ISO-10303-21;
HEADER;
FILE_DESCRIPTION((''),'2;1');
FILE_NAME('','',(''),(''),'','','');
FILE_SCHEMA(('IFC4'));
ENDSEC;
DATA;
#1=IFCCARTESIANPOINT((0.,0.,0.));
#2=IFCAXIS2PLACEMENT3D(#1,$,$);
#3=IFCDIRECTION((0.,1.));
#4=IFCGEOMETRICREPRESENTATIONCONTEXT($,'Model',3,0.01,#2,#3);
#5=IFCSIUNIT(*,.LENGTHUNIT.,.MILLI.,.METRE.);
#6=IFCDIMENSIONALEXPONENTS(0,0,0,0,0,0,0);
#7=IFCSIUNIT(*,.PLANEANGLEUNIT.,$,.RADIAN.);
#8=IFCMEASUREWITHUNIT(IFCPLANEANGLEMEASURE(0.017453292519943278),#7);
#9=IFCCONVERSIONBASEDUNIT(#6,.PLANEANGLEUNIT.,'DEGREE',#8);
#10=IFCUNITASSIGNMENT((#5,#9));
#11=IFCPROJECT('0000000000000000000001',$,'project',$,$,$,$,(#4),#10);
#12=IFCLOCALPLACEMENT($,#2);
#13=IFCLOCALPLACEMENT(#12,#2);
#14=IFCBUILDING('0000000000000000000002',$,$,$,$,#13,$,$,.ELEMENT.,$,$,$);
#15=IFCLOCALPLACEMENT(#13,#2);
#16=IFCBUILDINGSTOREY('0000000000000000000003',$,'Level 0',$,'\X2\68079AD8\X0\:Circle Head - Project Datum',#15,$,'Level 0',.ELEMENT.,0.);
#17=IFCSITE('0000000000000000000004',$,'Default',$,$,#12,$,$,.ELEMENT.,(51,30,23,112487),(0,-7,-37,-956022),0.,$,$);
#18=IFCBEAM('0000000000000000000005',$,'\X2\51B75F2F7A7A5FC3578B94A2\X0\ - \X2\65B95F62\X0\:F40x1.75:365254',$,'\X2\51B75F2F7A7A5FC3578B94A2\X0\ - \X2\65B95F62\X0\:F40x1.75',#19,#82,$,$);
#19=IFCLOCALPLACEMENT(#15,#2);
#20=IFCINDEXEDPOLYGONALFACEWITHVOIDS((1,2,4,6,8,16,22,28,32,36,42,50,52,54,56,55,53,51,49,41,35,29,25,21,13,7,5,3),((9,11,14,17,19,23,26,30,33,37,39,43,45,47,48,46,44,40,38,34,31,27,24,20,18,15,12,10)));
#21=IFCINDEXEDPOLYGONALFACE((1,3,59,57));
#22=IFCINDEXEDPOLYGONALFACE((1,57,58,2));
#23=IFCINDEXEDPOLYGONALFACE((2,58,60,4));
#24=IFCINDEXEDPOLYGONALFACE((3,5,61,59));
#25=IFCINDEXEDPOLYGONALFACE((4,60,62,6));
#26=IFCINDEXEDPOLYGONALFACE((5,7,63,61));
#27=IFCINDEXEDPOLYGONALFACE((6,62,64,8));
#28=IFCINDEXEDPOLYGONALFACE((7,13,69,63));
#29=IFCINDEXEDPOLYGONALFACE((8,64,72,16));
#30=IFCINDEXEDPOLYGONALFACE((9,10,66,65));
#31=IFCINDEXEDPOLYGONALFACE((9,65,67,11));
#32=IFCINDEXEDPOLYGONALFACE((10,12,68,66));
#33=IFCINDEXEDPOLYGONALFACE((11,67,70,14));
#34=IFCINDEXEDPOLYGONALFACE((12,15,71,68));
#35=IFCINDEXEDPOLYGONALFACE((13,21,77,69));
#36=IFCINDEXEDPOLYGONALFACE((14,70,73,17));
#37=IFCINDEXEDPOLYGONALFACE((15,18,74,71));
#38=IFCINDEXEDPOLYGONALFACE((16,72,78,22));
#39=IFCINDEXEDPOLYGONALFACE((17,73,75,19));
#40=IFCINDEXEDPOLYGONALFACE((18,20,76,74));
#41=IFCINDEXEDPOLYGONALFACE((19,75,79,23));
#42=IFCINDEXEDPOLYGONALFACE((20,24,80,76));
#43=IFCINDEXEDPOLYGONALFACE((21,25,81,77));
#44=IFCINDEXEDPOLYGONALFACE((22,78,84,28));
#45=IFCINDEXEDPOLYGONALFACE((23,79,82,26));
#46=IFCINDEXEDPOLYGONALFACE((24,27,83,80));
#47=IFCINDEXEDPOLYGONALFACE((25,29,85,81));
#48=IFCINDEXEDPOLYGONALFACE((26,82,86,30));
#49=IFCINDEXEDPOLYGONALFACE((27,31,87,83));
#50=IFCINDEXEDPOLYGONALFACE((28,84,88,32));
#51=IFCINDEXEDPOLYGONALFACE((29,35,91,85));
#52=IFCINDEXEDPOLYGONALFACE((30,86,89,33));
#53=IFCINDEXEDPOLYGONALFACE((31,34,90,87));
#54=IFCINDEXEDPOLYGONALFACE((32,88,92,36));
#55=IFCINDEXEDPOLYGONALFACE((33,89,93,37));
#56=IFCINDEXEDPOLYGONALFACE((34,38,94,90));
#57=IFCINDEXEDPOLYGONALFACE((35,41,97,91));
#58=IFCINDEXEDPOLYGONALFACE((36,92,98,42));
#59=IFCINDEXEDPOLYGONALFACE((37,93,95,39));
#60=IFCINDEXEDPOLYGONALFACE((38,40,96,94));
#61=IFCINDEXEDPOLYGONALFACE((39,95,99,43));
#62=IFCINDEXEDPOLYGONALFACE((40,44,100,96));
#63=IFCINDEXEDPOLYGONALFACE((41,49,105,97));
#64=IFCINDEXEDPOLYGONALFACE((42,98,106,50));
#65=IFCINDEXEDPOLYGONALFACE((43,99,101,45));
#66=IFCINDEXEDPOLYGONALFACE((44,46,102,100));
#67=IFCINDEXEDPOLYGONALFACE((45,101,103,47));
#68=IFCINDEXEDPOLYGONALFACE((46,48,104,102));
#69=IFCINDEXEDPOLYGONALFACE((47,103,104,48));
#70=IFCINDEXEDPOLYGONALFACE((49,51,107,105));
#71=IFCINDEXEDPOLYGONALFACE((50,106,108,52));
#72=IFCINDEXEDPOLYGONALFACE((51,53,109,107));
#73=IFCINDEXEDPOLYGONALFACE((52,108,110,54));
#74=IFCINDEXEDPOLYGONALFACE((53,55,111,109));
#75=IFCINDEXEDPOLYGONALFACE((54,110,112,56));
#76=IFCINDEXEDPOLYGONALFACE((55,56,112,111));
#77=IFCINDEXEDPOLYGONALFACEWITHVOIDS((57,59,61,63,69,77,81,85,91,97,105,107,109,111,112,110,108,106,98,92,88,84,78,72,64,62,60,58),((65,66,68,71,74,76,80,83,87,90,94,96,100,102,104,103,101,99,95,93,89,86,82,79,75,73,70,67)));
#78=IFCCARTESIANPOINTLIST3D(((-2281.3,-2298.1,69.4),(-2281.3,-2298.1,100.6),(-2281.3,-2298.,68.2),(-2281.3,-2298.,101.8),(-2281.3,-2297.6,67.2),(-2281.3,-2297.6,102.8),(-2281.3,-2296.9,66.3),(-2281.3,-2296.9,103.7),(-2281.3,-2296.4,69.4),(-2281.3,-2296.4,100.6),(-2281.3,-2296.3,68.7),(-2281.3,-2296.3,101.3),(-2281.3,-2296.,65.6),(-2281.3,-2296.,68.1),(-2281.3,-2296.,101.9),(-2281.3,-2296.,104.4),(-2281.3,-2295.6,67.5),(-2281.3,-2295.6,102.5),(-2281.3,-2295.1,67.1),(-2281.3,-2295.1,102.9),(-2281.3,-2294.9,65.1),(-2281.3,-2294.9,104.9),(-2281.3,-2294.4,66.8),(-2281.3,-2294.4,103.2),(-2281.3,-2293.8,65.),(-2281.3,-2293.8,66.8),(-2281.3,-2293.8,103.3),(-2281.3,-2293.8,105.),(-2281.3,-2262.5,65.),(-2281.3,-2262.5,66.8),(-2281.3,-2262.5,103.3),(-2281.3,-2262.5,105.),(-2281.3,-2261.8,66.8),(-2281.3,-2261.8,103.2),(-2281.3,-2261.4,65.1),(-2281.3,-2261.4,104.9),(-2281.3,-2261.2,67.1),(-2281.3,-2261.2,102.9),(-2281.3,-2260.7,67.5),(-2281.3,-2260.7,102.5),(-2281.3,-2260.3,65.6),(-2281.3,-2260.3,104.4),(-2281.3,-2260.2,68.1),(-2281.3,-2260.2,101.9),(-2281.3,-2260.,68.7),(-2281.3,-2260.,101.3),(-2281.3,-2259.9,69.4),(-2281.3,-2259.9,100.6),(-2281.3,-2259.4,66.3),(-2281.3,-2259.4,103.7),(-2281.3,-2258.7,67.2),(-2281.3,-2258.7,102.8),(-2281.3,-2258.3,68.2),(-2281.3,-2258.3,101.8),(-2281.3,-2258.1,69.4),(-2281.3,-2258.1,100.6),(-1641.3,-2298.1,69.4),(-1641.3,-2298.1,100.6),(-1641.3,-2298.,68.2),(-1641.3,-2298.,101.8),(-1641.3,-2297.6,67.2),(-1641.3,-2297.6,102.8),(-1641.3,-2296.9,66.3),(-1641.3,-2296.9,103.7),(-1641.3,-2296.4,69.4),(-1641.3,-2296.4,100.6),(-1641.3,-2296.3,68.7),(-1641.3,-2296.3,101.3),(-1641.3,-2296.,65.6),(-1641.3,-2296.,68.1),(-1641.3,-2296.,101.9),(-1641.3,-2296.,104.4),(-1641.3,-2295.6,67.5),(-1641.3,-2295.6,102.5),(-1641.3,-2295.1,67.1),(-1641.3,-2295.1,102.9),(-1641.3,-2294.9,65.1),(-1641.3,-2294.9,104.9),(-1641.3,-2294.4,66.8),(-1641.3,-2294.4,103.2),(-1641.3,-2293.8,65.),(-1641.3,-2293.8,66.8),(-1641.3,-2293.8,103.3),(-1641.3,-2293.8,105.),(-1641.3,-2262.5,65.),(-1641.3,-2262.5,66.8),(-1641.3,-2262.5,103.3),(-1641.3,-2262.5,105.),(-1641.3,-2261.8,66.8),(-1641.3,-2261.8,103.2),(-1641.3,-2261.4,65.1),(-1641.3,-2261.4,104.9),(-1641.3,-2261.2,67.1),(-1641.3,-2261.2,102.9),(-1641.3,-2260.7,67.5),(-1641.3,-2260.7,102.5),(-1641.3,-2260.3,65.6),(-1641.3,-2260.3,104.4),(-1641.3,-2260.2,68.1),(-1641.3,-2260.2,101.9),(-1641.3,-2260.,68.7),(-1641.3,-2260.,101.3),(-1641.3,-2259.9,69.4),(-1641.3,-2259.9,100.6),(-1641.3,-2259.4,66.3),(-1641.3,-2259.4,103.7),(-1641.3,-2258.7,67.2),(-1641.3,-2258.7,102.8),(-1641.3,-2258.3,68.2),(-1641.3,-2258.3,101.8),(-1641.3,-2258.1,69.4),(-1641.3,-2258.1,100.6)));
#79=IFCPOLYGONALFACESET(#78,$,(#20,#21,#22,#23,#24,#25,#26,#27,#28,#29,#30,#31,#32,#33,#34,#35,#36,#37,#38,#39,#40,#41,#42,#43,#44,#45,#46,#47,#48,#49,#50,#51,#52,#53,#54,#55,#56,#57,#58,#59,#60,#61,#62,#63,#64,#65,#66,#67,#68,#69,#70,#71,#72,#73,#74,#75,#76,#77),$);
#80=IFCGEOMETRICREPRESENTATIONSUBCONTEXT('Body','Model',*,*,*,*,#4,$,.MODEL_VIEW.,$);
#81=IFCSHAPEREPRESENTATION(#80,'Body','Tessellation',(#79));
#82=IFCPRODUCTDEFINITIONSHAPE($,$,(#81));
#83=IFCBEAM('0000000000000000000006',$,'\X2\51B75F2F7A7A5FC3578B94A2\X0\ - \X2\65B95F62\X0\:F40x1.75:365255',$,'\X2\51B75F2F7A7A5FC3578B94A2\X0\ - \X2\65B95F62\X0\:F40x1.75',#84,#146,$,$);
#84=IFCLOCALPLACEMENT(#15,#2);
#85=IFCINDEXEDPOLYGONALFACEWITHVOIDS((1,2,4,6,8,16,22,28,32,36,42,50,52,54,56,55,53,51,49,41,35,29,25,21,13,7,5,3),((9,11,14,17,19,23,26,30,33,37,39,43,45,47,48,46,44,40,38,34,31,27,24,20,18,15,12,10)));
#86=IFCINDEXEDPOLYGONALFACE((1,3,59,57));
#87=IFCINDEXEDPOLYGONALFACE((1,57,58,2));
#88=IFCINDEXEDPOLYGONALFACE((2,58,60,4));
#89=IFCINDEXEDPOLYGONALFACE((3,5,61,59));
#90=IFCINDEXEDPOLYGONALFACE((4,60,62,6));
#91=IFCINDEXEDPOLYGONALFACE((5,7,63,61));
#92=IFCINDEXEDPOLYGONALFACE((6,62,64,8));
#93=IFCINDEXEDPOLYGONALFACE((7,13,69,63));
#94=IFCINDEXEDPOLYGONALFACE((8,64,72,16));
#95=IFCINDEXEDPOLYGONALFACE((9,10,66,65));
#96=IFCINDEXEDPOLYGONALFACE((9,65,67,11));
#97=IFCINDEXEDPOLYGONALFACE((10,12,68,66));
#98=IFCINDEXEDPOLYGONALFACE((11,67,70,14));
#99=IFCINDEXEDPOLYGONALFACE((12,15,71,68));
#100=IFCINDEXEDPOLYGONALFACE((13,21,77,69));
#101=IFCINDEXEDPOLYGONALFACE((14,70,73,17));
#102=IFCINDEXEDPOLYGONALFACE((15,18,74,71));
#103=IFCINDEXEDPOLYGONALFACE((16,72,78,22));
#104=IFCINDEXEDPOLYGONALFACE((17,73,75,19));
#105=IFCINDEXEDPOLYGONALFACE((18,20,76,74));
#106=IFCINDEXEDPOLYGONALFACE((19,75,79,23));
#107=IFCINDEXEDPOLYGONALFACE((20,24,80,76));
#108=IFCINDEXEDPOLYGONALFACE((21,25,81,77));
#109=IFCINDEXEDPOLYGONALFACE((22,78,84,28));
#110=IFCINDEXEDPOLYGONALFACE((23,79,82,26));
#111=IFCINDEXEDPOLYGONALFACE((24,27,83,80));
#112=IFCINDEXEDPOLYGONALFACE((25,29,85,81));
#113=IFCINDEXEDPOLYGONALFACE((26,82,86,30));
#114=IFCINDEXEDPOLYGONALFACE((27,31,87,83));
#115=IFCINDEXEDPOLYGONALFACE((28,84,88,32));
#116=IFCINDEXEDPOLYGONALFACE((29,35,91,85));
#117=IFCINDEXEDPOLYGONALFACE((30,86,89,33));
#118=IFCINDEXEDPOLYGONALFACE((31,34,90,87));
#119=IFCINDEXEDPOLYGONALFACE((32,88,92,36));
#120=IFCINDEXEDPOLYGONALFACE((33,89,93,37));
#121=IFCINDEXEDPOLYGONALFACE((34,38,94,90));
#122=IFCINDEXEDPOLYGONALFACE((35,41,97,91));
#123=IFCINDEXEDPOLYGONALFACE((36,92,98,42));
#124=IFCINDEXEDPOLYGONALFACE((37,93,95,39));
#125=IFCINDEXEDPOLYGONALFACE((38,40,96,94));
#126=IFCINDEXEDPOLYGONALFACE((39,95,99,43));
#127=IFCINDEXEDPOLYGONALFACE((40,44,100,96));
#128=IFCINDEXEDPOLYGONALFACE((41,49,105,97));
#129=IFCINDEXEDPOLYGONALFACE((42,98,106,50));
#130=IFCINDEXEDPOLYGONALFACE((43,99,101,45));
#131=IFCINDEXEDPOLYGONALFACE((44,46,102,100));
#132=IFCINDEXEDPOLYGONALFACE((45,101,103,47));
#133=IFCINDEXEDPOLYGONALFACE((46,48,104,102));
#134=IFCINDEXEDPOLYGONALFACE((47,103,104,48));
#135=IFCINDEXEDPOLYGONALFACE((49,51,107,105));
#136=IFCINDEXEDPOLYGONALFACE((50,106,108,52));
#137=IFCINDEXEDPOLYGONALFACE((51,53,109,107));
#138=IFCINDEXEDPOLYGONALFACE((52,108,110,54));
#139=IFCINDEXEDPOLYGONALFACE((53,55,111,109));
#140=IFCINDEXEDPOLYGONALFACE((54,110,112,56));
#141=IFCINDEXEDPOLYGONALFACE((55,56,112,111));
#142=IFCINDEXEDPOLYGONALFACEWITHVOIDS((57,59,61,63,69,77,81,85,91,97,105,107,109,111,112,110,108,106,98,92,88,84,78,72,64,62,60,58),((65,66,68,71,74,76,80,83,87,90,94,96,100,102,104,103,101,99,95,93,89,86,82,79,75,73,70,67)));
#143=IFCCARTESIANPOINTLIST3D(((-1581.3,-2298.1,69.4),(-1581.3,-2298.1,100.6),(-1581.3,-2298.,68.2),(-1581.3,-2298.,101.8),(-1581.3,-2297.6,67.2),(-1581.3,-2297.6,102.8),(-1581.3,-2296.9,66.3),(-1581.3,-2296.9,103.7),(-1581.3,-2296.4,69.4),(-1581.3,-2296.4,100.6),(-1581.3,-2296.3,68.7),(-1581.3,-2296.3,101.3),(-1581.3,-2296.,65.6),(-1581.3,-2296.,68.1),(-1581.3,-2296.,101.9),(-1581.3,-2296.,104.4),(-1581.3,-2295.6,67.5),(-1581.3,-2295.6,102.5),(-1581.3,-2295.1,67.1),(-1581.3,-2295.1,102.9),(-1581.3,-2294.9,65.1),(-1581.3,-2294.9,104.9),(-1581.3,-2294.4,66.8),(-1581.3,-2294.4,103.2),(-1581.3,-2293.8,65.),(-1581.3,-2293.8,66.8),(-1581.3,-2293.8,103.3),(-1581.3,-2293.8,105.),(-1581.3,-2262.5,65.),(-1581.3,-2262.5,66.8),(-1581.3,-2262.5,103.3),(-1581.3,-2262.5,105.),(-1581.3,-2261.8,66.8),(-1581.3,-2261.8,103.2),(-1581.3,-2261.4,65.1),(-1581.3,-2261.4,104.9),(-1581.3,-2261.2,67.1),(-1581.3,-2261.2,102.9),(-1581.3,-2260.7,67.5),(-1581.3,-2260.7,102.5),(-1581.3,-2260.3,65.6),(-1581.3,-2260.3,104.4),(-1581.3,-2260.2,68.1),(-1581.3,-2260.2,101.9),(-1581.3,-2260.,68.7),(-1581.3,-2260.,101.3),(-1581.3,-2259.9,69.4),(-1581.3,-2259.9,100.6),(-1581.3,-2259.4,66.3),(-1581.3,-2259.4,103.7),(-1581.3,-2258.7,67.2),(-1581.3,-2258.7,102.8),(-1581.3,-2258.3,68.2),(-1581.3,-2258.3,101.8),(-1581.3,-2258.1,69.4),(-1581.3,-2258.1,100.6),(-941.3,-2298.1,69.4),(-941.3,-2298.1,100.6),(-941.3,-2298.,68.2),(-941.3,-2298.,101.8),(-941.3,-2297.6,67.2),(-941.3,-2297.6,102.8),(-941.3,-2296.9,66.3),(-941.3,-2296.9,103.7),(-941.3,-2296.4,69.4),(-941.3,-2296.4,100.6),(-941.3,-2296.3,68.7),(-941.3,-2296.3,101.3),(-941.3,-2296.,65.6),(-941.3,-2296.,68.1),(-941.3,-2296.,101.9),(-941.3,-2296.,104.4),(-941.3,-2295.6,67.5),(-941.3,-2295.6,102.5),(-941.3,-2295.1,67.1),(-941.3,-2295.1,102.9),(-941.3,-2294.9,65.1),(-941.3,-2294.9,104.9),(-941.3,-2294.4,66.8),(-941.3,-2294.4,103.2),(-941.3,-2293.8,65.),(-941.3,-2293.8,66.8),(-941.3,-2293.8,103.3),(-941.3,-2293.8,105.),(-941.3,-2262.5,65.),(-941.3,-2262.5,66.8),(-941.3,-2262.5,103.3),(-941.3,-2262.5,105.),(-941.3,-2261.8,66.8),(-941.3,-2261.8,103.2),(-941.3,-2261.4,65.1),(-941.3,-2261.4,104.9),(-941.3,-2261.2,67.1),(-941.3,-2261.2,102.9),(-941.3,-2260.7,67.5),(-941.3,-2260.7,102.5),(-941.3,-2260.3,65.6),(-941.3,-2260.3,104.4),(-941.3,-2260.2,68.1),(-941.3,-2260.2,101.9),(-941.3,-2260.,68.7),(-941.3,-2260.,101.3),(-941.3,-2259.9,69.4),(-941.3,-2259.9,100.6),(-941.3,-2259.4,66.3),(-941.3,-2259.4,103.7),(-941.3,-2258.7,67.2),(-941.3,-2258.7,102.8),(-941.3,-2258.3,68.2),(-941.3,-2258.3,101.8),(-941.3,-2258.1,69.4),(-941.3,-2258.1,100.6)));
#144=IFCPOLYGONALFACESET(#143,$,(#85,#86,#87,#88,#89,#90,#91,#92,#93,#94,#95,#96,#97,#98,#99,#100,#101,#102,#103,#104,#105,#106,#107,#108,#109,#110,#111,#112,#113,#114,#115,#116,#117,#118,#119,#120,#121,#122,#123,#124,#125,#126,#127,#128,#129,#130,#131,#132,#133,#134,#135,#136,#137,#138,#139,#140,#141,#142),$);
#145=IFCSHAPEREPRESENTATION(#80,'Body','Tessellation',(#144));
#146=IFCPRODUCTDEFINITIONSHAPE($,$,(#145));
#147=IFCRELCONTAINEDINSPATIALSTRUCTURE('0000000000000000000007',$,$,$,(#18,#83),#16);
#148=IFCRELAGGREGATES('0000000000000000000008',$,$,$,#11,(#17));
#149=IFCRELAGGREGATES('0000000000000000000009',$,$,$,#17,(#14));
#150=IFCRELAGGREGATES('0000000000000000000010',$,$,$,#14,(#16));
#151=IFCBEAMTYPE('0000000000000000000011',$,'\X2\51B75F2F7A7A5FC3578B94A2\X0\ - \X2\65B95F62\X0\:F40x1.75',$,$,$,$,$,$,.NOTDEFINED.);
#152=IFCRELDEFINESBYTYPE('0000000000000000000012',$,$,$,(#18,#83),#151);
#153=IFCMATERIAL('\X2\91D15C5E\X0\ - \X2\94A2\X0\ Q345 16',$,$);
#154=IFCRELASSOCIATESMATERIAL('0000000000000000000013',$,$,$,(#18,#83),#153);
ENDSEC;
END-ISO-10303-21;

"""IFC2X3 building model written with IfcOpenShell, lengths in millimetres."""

from ifc_helpers import new_model, entity, si_unit, converted_unit, direction, frame, frame_2d, origin, place, context, subcontext, project, spatial, polyline, circle_curve, parameter, trimmed, segment, composite_curve, outline, extrude, material, type_object, element, save


model = new_model("IFC2X3")

# Units and contexts
model_context = context("Model", 3, precision=0.01, world=origin(), true_north=direction((0.0, 1.0)))
body_context = subcontext(model_context, "Body", "Model", "MODEL_VIEW")
ifc_project = project(units=[si_unit("LENGTHUNIT", "METRE", prefix="MILLI"), converted_unit("PLANEANGLEUNIT", "DEGREE", entity("IfcPlaneAngleMeasure", 0.017453292519943278), si_unit("PLANEANGLEUNIT", "RADIAN"), dimensions=[0, 0, 0, 0, 0, 0, 0])], contexts=[model_context])

# Site, building, storey
site_placement = place(None, origin())
site = spatial("IfcSite", under=ifc_project, at=site_placement, Name="Default", CompositionType="ELEMENT", RefLatitude=(51, 30, 23, 112487), RefLongitude=(0, -7, -37, -956022), RefElevation=0.0)
building_placement = place(site_placement, origin())
building = spatial("IfcBuilding", under=site, at=building_placement, CompositionType="ELEMENT")
storey_placement = place(building_placement, origin())
storey = spatial("IfcBuildingStorey", under=building, at=storey_placement, Name="Level 0", ObjectType="标高:Circle Head - Project Datum", LongName="Level 0", CompositionType="ELEMENT", Elevation=0.0)

# Beams
ifc_material_1 = material(Name="金属 - 钢 Q345 16")
beam_type_1 = type_object("IfcBeamType", Name="冷弯空心型钢 - 方形:F40x1.75", PredefinedType="NOTDEFINED")
beam_1_placement = place(storey_placement, frame((-1776.3, -2278.1, 105.0), z_axis=(0.0, 0.0, 1.0), x_axis=(-1.0, 0.0, 0.0)))
element("IfcBeam", 1, at=beam_1_placement, inside=storey, type_object=beam_type_1, material=ifc_material_1, Name="冷弯空心型钢 - 方形:F40x1.75:365254", ObjectType="冷弯空心型钢 - 方形:F40x1.75", context=body_context, shape_type="SweptSolid", body=[
    extrude(outline(composite_curve([segment(trimmed(circle_curve(frame_2d((-15.6, 15.6), x_axis=(1.0, 0.0)), 4.4), [parameter(90.0)], [parameter(180.0)], True, "PARAMETER"), True, "CONTINUOUS"), segment(polyline([(-20.0, 15.6), (-20.0, -15.6)]), True, "CONTINUOUS"), segment(trimmed(circle_curve(frame_2d((-15.6, -15.6), x_axis=(1.0, 0.0)), 4.4), [parameter(180.0)], [parameter(270.0)], True, "PARAMETER"), True, "CONTINUOUS"), segment(polyline([(-15.6, -20.0), (15.6, -20.0)]), True, "CONTINUOUS"), segment(trimmed(circle_curve(frame_2d((15.6, -15.6), x_axis=(1.0, 0.0)), 4.4), [parameter(270.0)], [parameter(0.0)], True, "PARAMETER"), True, "CONTINUOUS"), segment(polyline([(20.0, -15.6), (20.0, 15.6)]), True, "CONTINUOUS"), segment(trimmed(circle_curve(frame_2d((15.6, 15.6), x_axis=(1.0, 0.0)), 4.4), [parameter(0.0)], [parameter(90.0)], True, "PARAMETER"), True, "CONTINUOUS"), segment(polyline([(15.6, 20.0), (-15.6, 20.0)]), True, "CONTINUOUS")], self_intersect=False), holes=[composite_curve([segment(polyline([(-15.6, 18.3), (15.6, 18.3)]), True, "CONTINUOUS"), segment(trimmed(circle_curve(frame_2d((15.6, 15.6), x_axis=(1.0, 0.0)), 2.6), [parameter(0.0)], [parameter(90.0)], True, "PARAMETER"), False, "CONTINUOUS"), segment(polyline([(18.2, 15.6), (18.2, -15.6)]), True, "CONTINUOUS"), segment(trimmed(circle_curve(frame_2d((15.6, -15.6), x_axis=(1.0, 0.0)), 2.6), [parameter(270.0)], [parameter(360.0)], True, "PARAMETER"), False, "CONTINUOUS"), segment(polyline([(15.6, -18.2), (-15.6, -18.2)]), True, "CONTINUOUS"), segment(trimmed(circle_curve(frame_2d((-15.6, -15.6), x_axis=(1.0, 0.0)), 2.6), [parameter(180.0)], [parameter(270.0)], True, "PARAMETER"), False, "CONTINUOUS"), segment(polyline([(-18.3, -15.6), (-18.3, 15.6)]), True, "CONTINUOUS"), segment(trimmed(circle_curve(frame_2d((-15.6, 15.6), x_axis=(1.0, 0.0)), 2.6), [parameter(90.0)], [parameter(180.0)], True, "PARAMETER"), False, "CONTINUOUS")], self_intersect=False)]), frame((-135.0, 0.0, -20.0), z_axis=(1.0, 0.0, 0.0), x_axis=(0.0, 1.0, 0.0)), (0.0, 0.0, 1.0), 640.0),
])
beam_2_placement = place(storey_placement, frame((-1076.3, -2278.1, 105.0), z_axis=(0.0, 0.0, 1.0), x_axis=(-1.0, 0.0, 0.0)))
element("IfcBeam", 2, at=beam_2_placement, inside=storey, type_object=beam_type_1, material=ifc_material_1, Name="冷弯空心型钢 - 方形:F40x1.75:365255", ObjectType="冷弯空心型钢 - 方形:F40x1.75", context=body_context, shape_type="SweptSolid", body=[
    extrude(outline(composite_curve([segment(trimmed(circle_curve(frame_2d((-15.6, 15.6), x_axis=(1.0, 0.0)), 4.4), [parameter(90.0)], [parameter(180.0)], True, "PARAMETER"), True, "CONTINUOUS"), segment(polyline([(-20.0, 15.6), (-20.0, -15.6)]), True, "CONTINUOUS"), segment(trimmed(circle_curve(frame_2d((-15.6, -15.6), x_axis=(1.0, 0.0)), 4.4), [parameter(180.0)], [parameter(270.0)], True, "PARAMETER"), True, "CONTINUOUS"), segment(polyline([(-15.6, -20.0), (15.6, -20.0)]), True, "CONTINUOUS"), segment(trimmed(circle_curve(frame_2d((15.6, -15.6), x_axis=(1.0, 0.0)), 4.4), [parameter(270.0)], [parameter(0.0)], True, "PARAMETER"), True, "CONTINUOUS"), segment(polyline([(20.0, -15.6), (20.0, 15.6)]), True, "CONTINUOUS"), segment(trimmed(circle_curve(frame_2d((15.6, 15.6), x_axis=(1.0, 0.0)), 4.4), [parameter(0.0)], [parameter(90.0)], True, "PARAMETER"), True, "CONTINUOUS"), segment(polyline([(15.6, 20.0), (-15.6, 20.0)]), True, "CONTINUOUS")], self_intersect=False), holes=[composite_curve([segment(polyline([(-15.6, 18.3), (15.6, 18.3)]), True, "CONTINUOUS"), segment(trimmed(circle_curve(frame_2d((15.6, 15.6), x_axis=(1.0, 0.0)), 2.6), [parameter(0.0)], [parameter(90.0)], True, "PARAMETER"), False, "CONTINUOUS"), segment(polyline([(18.2, 15.6), (18.2, -15.6)]), True, "CONTINUOUS"), segment(trimmed(circle_curve(frame_2d((15.6, -15.6), x_axis=(1.0, 0.0)), 2.6), [parameter(270.0)], [parameter(360.0)], True, "PARAMETER"), False, "CONTINUOUS"), segment(polyline([(15.6, -18.2), (-15.6, -18.2)]), True, "CONTINUOUS"), segment(trimmed(circle_curve(frame_2d((-15.6, -15.6), x_axis=(1.0, 0.0)), 2.6), [parameter(180.0)], [parameter(270.0)], True, "PARAMETER"), False, "CONTINUOUS"), segment(polyline([(-18.3, -15.6), (-18.3, 15.6)]), True, "CONTINUOUS"), segment(trimmed(circle_curve(frame_2d((-15.6, 15.6), x_axis=(1.0, 0.0)), 2.6), [parameter(90.0)], [parameter(180.0)], True, "PARAMETER"), False, "CONTINUOUS")], self_intersect=False)]), frame((-135.0, 0.0, -20.0), z_axis=(1.0, 0.0, 0.0), x_axis=(0.0, 1.0, 0.0)), (0.0, 0.0, 1.0), 640.0),
])

save(model, "model.ifc")
